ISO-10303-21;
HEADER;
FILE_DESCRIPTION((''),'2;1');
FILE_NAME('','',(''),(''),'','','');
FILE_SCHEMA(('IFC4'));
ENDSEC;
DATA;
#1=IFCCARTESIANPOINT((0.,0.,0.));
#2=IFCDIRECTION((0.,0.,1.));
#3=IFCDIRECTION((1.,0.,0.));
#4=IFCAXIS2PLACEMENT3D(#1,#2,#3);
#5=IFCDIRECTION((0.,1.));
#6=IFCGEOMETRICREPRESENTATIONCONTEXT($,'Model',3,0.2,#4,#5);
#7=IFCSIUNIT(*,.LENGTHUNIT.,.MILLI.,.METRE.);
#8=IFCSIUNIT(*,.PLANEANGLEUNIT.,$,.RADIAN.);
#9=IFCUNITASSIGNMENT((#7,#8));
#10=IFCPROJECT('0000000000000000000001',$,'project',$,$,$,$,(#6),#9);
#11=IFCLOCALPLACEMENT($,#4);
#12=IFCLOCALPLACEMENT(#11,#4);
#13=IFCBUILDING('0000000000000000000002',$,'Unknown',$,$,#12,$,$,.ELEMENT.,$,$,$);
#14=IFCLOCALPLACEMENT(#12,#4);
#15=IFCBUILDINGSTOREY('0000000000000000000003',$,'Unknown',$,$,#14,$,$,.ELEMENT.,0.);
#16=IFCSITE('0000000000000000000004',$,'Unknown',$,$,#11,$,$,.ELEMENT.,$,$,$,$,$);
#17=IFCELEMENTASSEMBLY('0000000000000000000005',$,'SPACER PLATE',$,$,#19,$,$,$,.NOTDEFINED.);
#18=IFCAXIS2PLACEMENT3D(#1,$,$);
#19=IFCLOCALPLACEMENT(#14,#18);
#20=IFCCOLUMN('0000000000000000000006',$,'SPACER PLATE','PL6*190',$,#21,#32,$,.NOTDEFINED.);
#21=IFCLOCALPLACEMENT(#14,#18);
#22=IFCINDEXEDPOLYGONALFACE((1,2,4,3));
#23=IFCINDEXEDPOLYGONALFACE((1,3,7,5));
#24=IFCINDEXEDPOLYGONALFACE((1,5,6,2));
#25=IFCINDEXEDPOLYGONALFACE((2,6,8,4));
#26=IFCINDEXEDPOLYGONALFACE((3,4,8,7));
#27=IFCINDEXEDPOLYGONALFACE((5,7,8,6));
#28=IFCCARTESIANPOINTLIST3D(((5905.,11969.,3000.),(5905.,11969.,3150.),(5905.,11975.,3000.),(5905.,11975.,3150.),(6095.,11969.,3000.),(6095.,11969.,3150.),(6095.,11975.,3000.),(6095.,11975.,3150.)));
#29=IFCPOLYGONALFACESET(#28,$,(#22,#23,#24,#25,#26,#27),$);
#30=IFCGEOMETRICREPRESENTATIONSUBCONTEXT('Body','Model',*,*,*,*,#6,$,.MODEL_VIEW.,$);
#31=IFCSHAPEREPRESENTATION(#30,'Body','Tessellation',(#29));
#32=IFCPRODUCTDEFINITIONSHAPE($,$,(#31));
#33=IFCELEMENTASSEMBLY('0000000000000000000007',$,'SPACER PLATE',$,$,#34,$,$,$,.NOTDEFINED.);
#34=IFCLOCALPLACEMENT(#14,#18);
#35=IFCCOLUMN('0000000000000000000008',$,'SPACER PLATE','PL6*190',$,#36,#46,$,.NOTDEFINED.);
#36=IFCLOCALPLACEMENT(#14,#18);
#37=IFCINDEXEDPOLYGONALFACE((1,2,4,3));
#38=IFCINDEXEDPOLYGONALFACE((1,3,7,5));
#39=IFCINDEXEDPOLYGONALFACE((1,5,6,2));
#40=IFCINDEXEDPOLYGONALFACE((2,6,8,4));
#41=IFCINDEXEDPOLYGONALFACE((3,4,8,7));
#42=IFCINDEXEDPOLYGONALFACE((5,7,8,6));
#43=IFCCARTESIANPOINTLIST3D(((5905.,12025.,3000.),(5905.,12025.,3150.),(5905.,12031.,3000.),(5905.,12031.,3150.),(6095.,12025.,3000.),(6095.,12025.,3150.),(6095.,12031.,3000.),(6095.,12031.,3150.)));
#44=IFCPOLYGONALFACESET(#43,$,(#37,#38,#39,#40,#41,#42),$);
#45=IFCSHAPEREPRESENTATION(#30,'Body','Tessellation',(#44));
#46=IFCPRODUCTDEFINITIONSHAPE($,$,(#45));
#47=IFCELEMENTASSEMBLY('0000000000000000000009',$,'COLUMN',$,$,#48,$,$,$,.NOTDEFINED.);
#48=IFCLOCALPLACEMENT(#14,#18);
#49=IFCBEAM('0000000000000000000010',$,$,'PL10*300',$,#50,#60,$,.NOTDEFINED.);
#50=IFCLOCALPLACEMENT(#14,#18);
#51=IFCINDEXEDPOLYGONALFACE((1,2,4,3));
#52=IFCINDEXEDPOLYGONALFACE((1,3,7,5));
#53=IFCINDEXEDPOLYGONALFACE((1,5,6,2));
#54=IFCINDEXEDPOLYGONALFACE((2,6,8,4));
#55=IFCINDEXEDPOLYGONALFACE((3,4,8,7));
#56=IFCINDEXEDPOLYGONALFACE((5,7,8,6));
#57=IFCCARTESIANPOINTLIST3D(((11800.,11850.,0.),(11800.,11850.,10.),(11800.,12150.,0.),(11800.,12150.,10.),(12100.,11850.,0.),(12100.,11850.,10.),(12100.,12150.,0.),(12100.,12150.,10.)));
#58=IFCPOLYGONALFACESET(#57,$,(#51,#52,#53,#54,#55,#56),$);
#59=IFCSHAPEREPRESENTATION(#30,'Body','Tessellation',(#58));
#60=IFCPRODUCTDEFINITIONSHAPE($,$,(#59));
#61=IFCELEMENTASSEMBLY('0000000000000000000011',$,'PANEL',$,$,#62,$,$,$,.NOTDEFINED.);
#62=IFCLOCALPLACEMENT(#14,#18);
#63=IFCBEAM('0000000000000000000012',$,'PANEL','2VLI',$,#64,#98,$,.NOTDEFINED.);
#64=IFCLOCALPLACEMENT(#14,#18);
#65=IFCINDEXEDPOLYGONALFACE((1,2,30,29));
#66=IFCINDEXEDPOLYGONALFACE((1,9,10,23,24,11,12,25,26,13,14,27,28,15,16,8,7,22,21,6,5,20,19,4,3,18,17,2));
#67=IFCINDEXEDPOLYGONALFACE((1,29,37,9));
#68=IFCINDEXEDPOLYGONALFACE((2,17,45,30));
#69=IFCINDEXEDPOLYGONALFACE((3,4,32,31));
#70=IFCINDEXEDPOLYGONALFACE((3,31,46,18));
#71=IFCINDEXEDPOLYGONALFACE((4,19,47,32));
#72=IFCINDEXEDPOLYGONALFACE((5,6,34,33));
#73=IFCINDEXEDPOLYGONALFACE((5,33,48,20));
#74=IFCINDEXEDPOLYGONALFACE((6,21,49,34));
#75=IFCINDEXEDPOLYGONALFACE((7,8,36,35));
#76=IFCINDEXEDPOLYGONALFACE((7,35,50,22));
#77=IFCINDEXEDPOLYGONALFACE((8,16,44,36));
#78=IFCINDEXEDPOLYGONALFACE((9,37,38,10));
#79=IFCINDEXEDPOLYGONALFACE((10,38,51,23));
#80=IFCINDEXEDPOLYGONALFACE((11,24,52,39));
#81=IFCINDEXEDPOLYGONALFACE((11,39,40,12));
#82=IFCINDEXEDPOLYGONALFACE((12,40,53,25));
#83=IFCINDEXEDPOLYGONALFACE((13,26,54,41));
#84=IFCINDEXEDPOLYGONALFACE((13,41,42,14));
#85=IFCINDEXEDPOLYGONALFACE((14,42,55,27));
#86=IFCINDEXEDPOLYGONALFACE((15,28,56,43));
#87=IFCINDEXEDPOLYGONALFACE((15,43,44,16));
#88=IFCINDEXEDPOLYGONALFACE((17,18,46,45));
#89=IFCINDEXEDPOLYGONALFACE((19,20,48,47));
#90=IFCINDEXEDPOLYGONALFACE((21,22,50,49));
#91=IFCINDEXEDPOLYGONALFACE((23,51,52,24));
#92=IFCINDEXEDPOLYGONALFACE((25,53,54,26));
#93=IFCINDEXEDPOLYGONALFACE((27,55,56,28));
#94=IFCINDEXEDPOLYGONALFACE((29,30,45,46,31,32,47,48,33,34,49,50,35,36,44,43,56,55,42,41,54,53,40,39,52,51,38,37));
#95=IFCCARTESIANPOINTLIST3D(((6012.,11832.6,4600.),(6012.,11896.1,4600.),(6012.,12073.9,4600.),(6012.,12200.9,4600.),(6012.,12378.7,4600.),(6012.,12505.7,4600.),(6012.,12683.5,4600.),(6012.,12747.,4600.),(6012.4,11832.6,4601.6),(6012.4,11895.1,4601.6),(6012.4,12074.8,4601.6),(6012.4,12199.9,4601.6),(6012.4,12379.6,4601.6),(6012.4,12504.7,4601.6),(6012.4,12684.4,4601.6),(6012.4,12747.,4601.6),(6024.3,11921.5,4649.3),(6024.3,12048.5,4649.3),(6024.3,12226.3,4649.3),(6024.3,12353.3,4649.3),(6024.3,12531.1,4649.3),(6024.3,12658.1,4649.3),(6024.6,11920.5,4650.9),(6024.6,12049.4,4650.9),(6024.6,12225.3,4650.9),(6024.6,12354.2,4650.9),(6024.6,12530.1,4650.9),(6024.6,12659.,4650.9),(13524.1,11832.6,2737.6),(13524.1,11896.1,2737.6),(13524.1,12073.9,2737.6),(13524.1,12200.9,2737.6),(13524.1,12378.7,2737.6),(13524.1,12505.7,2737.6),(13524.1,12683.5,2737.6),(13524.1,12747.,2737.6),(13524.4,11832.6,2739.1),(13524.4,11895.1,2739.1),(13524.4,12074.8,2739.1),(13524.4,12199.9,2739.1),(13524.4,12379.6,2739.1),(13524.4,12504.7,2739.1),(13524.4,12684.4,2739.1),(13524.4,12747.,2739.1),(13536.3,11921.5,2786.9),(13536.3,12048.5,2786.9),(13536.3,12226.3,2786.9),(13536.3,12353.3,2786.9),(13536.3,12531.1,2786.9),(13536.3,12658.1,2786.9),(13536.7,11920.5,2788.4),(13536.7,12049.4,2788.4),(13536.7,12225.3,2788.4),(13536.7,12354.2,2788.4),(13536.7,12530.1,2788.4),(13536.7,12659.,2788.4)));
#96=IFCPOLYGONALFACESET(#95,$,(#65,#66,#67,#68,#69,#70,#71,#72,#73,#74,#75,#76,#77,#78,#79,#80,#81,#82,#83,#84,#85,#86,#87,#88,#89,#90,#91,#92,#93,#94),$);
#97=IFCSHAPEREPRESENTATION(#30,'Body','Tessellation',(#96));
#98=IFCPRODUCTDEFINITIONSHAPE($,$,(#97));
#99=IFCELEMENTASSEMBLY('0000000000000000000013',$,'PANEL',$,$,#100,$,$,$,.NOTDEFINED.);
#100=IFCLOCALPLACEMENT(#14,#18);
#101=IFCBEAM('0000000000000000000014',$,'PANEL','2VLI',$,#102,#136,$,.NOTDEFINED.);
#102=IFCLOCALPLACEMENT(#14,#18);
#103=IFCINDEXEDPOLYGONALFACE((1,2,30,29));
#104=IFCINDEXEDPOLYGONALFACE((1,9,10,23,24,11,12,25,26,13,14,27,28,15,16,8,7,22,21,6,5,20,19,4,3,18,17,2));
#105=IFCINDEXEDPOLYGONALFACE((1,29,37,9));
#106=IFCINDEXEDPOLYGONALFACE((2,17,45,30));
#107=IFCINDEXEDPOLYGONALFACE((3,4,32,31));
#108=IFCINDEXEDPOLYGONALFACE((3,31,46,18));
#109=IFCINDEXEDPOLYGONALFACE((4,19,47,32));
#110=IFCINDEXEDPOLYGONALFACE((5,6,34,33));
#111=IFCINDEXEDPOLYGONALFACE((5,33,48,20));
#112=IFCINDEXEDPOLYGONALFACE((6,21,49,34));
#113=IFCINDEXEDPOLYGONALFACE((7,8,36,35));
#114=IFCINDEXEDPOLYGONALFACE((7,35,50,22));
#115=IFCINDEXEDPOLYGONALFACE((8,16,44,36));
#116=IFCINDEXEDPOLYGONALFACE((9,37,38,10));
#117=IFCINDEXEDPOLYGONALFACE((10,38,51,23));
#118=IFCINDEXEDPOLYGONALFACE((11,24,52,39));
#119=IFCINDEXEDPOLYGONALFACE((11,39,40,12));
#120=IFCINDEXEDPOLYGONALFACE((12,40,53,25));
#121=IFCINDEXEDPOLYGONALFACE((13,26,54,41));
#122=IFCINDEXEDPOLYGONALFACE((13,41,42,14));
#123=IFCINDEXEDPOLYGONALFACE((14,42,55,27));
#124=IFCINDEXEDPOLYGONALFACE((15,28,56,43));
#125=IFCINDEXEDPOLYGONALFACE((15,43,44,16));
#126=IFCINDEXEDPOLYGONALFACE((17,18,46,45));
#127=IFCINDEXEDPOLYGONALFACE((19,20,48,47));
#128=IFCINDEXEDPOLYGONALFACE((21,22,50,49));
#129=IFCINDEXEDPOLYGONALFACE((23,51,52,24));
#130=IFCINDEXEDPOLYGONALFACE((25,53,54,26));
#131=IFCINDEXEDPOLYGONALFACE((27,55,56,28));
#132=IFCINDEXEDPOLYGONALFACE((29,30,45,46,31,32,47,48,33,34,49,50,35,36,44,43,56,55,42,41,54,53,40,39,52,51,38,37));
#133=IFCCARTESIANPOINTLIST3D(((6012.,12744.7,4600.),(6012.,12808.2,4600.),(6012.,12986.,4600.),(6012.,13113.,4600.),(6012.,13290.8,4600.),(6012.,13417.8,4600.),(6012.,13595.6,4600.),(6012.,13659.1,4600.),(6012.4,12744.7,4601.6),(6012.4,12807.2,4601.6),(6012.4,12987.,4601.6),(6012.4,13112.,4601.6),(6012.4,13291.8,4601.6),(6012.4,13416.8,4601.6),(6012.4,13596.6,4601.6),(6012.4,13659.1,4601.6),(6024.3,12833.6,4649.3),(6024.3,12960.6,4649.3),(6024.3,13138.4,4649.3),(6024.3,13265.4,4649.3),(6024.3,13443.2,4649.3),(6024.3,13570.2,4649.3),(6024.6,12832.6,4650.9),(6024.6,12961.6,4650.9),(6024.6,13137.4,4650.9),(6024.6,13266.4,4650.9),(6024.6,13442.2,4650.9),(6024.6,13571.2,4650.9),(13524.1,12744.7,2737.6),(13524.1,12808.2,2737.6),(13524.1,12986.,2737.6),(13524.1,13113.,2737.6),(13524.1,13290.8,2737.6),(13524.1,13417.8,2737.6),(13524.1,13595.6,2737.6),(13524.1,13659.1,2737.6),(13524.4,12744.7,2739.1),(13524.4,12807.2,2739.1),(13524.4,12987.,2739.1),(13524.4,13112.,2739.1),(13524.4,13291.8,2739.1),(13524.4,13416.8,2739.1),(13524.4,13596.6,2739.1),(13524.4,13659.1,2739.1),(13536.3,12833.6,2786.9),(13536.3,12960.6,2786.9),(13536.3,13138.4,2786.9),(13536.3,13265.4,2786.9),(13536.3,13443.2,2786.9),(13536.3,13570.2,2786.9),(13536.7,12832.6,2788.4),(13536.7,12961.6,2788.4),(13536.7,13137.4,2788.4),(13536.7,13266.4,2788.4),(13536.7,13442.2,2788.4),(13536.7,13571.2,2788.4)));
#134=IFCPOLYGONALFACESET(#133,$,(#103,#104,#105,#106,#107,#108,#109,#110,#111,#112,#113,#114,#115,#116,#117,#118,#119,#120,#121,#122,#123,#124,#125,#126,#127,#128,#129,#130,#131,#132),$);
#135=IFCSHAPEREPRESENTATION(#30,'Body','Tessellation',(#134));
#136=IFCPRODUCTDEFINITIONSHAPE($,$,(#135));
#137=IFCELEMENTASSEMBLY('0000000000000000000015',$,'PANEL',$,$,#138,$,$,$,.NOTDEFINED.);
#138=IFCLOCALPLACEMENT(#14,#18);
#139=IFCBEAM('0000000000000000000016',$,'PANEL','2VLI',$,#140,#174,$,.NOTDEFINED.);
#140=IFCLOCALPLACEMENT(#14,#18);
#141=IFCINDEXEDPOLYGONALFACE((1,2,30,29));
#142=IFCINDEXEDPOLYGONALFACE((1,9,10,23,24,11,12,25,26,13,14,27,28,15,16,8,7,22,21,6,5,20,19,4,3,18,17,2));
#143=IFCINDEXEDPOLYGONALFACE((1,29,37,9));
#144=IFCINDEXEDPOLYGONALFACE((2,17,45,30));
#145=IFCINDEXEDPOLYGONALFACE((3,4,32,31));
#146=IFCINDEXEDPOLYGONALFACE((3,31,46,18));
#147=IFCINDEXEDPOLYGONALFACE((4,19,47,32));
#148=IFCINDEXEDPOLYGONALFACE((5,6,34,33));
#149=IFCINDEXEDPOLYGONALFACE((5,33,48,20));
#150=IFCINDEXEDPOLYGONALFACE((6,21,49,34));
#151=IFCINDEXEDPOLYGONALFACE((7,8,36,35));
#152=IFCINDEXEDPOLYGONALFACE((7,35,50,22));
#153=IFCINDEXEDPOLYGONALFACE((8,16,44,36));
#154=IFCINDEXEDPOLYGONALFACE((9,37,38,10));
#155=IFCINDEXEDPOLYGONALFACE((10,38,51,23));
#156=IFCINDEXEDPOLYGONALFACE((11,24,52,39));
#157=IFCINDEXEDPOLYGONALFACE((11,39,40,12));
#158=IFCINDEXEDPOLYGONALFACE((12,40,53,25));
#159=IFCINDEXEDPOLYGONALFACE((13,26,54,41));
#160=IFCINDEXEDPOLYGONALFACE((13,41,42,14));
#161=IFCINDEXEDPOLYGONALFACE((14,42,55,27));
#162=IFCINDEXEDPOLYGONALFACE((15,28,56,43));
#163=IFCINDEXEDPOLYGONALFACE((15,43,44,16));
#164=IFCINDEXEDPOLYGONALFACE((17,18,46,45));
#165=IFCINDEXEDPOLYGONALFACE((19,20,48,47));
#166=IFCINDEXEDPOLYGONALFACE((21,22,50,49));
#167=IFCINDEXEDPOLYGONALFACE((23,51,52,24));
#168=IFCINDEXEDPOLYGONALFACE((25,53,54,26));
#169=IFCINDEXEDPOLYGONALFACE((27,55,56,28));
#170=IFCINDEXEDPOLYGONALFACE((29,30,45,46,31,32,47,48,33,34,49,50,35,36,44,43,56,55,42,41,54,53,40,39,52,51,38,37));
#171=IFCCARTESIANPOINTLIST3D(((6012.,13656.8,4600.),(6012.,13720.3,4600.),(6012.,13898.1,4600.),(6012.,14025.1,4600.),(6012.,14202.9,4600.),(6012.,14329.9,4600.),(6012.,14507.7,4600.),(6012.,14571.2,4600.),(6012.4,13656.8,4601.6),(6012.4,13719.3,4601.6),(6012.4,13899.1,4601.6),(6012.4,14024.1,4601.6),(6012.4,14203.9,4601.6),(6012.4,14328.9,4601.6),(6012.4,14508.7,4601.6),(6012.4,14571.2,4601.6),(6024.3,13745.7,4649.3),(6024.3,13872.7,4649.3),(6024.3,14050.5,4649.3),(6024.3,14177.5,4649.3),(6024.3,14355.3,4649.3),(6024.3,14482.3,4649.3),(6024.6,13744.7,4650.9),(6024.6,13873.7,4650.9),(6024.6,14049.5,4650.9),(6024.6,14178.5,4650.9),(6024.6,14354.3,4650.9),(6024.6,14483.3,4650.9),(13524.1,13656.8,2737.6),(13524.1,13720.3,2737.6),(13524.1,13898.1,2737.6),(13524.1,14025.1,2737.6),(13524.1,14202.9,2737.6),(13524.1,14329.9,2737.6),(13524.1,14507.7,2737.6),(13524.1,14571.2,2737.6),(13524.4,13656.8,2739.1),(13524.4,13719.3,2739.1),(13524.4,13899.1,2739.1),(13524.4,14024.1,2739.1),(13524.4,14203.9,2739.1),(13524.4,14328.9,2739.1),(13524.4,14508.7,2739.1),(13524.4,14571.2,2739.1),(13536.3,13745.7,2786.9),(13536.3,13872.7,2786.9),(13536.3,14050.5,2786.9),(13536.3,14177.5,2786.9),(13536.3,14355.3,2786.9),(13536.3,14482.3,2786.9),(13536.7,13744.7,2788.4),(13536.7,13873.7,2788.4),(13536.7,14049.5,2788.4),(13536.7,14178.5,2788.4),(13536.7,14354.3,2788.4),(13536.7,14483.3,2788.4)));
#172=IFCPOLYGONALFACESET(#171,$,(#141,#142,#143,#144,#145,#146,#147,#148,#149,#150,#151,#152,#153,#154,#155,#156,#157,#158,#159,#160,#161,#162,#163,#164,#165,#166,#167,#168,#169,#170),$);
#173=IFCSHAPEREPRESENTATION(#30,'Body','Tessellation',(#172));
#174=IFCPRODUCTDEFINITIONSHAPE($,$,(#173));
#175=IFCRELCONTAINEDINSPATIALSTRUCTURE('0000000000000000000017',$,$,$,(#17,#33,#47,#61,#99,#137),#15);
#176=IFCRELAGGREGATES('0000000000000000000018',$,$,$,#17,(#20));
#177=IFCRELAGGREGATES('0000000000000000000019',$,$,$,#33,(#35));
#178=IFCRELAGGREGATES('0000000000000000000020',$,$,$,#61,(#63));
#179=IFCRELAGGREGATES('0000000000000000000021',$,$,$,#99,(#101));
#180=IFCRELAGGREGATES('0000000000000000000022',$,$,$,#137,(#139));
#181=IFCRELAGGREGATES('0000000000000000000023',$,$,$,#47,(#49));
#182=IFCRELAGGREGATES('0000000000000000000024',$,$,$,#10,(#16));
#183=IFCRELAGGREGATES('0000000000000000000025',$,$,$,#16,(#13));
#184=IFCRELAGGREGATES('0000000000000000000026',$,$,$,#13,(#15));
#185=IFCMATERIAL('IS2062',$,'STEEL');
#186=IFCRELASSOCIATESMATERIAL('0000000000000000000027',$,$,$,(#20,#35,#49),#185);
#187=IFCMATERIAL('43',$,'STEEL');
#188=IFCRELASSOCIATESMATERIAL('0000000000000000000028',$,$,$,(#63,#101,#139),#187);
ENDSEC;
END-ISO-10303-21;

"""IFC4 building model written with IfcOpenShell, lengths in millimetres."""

from ifc_helpers import new_model, si_unit, direction, frame, origin_with_axes, place, context, subcontext, project, spatial, line, indexed_curve, outline, extrude, material, element, aggregate, save


model = new_model("IFC4")

# Units and contexts
model_context = context("Model", 3, precision=0.2, world=origin_with_axes(), true_north=direction((0.0, 1.0)))
body_context = subcontext(model_context, "Body", "Model", "MODEL_VIEW")
ifc_project = project(units=[si_unit("LENGTHUNIT", "METRE", prefix="MILLI"), si_unit("PLANEANGLEUNIT", "RADIAN")], contexts=[model_context])

# Site, building, storey
site_placement = place(None, origin_with_axes())
site = spatial("IfcSite", under=ifc_project, at=site_placement, Name="Unknown", CompositionType="ELEMENT")
building_placement = place(site_placement, origin_with_axes())
building = spatial("IfcBuilding", under=site, at=building_placement, Name="Unknown", CompositionType="ELEMENT")
storey_placement = place(building_placement, origin_with_axes())
storey = spatial("IfcBuildingStorey", under=building, at=storey_placement, Name="Unknown", CompositionType="ELEMENT", Elevation=0.0)

# Element assemblies, columns
ifc_material_1 = material(Name="IS2062", Category="STEEL")
assembly_1_placement = place(storey_placement, frame((6000.0, 11972.0, 3000.0), z_axis=(0.0, -1.0, 0.0), x_axis=(0.0, 0.0, 1.0)))
assembly_1 = element("IfcElementAssembly", 1, at=assembly_1_placement, inside=storey, Name="SPACER PLATE", PredefinedType="NOTDEFINED")
column_1_placement = place(assembly_1_placement, origin_with_axes())
column_1 = element("IfcColumn", 2, at=column_1_placement, material=ifc_material_1, Name="SPACER PLATE", Description="PL6*190", PredefinedType="NOTDEFINED", context=body_context, shape_type="SolidModel", body=[
    extrude(outline(indexed_curve([(-3.0, -95.0), (3.0, -95.0), (3.0, 95.0), (-3.0, 95.0)], segments=[line(1, 2, 3, 4, 1)])), frame((0.0, 0.0, 0.0), z_axis=(-1.0, 0.0, 0.0), x_axis=(0.0, 0.0, 1.0)), (0.0, 0.0, -1.0), 150.0),
])
aggregate(assembly_1, [column_1])
assembly_2_placement = place(storey_placement, frame((6000.0, 12028.0, 3000.0), z_axis=(0.0, 1.0, 0.0), x_axis=(0.0, 0.0, 1.0)))
assembly_2 = element("IfcElementAssembly", 3, at=assembly_2_placement, inside=storey, Name="SPACER PLATE", PredefinedType="NOTDEFINED")
column_2_placement = place(assembly_2_placement, origin_with_axes())
column_2 = element("IfcColumn", 4, at=column_2_placement, material=ifc_material_1, Name="SPACER PLATE", Description="PL6*190", PredefinedType="NOTDEFINED", context=body_context, shape_type="SolidModel", body=[
    extrude(outline(indexed_curve([(-3.0, -95.0), (3.0, -95.0), (3.0, 95.0), (-3.0, 95.0)], segments=[line(1, 2, 3, 4, 1)])), frame((0.0, 0.0, 0.0), z_axis=(-1.0, 0.0, 0.0), x_axis=(0.0, 0.0, 1.0)), (0.0, 0.0, -1.0), 150.0),
])
aggregate(assembly_2, [column_2])

# Element assemblies, beams
assembly_3_placement = place(storey_placement, frame((11950.0, 12000.0, 0.0), z_axis=(0.0, 1.0, 0.0), x_axis=(0.0, 0.0, 1.0)))
assembly_3 = element("IfcElementAssembly", 5, at=assembly_3_placement, inside=storey, Name="COLUMN", PredefinedType="NOTDEFINED")
beam_1_placement = place(assembly_3_placement, frame((5.0, -150.0, 0.0), z_axis=(1.0, 0.0, 0.0), x_axis=(0.0, 1.0, 0.0)))
beam_1 = element("IfcBeam", 6, at=beam_1_placement, material=ifc_material_1, Description="PL10*300", PredefinedType="NOTDEFINED", context=body_context, shape_type="SolidModel", body=[
    extrude(outline(indexed_curve([(-5.0, -150.0), (5.0, -150.0), (5.0, 150.0), (-5.0, 150.0)], segments=[line(1, 2, 3, 4, 1)])), frame((0.0, 0.0, 0.0), z_axis=(-1.0, 0.0, 0.0), x_axis=(0.0, 0.0, 1.0)), (0.0, 0.0, -1.0), 300.0),
])
assembly_4_placement = place(storey_placement, frame((6018.3, 12289.8, 4625.5), z_axis=(0.0, -1.0, 0.0), x_axis=(0.970613, 0.0, -0.240648)))
assembly_4 = element("IfcElementAssembly", 7, at=assembly_4_placement, inside=storey, Name="PANEL", PredefinedType="NOTDEFINED")
ifc_material_2 = material(Name="43", Category="STEEL")
beam_2_placement = place(assembly_4_placement, origin_with_axes())
beam_2 = element("IfcBeam", 8, at=beam_2_placement, material=ifc_material_2, Name="PANEL", Description="2VLI", PredefinedType="NOTDEFINED", context=body_context, shape_type="SolidModel", body=[
    extrude(outline(indexed_curve([(457.2, -26.2), (457.2, -24.6), (394.7, -24.6), (369.3, 26.2), (240.3, 26.2), (214.9, -24.6), (89.9, -24.6), (64.5, 26.2), (-64.5, 26.2), (-89.9, -24.6), (-214.9, -24.6), (-240.3, 26.2), (-369.3, 26.2), (-394.7, -24.6), (-457.2, -24.6), (-457.2, -26.2), (-393.7, -26.2), (-368.3, 24.6), (-241.3, 24.6), (-215.9, -26.2), (-88.9, -26.2), (-63.5, 24.6), (63.5, 24.6), (88.9, -26.2), (215.9, -26.2), (241.3, 24.6), (368.3, 24.6), (393.7, -26.2)], segments=[line(1, 2, 3, 4, 5, 6, 7, 8, 9, 10, 11, 12, 13, 14, 15, 16, 17, 18, 19, 20, 21, 22, 23, 24, 25, 26, 27, 28, 1)])), frame((0.0, 0.0, 0.0), z_axis=(-1.0, 0.0, 0.0), x_axis=(0.0, 0.0, 1.0)), (0.0, 0.0, -1.0), 7739.5),
])
aggregate(assembly_4, [beam_2])
assembly_5_placement = place(storey_placement, frame((6018.3, 13201.9, 4625.5), z_axis=(0.0, -1.0, 0.0), x_axis=(0.970613, 0.0, -0.240648)))
assembly_5 = element("IfcElementAssembly", 9, at=assembly_5_placement, inside=storey, Name="PANEL", PredefinedType="NOTDEFINED")
beam_3_placement = place(assembly_5_placement, origin_with_axes())
beam_3 = element("IfcBeam", 10, at=beam_3_placement, material=ifc_material_2, Name="PANEL", Description="2VLI", PredefinedType="NOTDEFINED", context=body_context, shape_type="SolidModel", body=[
    extrude(outline(indexed_curve([(457.2, -26.2), (457.2, -24.6), (394.7, -24.6), (369.3, 26.2), (240.3, 26.2), (214.9, -24.6), (89.9, -24.6), (64.5, 26.2), (-64.5, 26.2), (-89.9, -24.6), (-214.9, -24.6), (-240.3, 26.2), (-369.3, 26.2), (-394.7, -24.6), (-457.2, -24.6), (-457.2, -26.2), (-393.7, -26.2), (-368.3, 24.6), (-241.3, 24.6), (-215.9, -26.2), (-88.9, -26.2), (-63.5, 24.6), (63.5, 24.6), (88.9, -26.2), (215.9, -26.2), (241.3, 24.6), (368.3, 24.6), (393.7, -26.2)], segments=[line(1, 2, 3, 4, 5, 6, 7, 8, 9, 10, 11, 12, 13, 14, 15, 16, 17, 18, 19, 20, 21, 22, 23, 24, 25, 26, 27, 28, 1)])), frame((0.0, 0.0, 0.0), z_axis=(-1.0, 0.0, 0.0), x_axis=(0.0, 0.0, 1.0)), (0.0, 0.0, -1.0), 7739.5),
])
aggregate(assembly_5, [beam_3])
assembly_6_placement = place(storey_placement, frame((6018.3, 14114.0, 4625.5), z_axis=(0.0, -1.0, 0.0), x_axis=(0.970613, 0.0, -0.240648)))
assembly_6 = element("IfcElementAssembly", 11, at=assembly_6_placement, inside=storey, Name="PANEL", PredefinedType="NOTDEFINED")
beam_4_placement = place(assembly_6_placement, origin_with_axes())
beam_4 = element("IfcBeam", 12, at=beam_4_placement, material=ifc_material_2, Name="PANEL", Description="2VLI", PredefinedType="NOTDEFINED", context=body_context, shape_type="SolidModel", body=[
    extrude(outline(indexed_curve([(457.2, -26.2), (457.2, -24.6), (394.7, -24.6), (369.3, 26.2), (240.3, 26.2), (214.9, -24.6), (89.9, -24.6), (64.5, 26.2), (-64.5, 26.2), (-89.9, -24.6), (-214.9, -24.6), (-240.3, 26.2), (-369.3, 26.2), (-394.7, -24.6), (-457.2, -24.6), (-457.2, -26.2), (-393.7, -26.2), (-368.3, 24.6), (-241.3, 24.6), (-215.9, -26.2), (-88.9, -26.2), (-63.5, 24.6), (63.5, 24.6), (88.9, -26.2), (215.9, -26.2), (241.3, 24.6), (368.3, 24.6), (393.7, -26.2)], segments=[line(1, 2, 3, 4, 5, 6, 7, 8, 9, 10, 11, 12, 13, 14, 15, 16, 17, 18, 19, 20, 21, 22, 23, 24, 25, 26, 27, 28, 1)])), frame((0.0, 0.0, 0.0), z_axis=(-1.0, 0.0, 0.0), x_axis=(0.0, 0.0, 1.0)), (0.0, 0.0, -1.0), 7739.5),
])
aggregate(assembly_6, [beam_4])

aggregate(assembly_3, [beam_1])

save(model, "model.ifc")
